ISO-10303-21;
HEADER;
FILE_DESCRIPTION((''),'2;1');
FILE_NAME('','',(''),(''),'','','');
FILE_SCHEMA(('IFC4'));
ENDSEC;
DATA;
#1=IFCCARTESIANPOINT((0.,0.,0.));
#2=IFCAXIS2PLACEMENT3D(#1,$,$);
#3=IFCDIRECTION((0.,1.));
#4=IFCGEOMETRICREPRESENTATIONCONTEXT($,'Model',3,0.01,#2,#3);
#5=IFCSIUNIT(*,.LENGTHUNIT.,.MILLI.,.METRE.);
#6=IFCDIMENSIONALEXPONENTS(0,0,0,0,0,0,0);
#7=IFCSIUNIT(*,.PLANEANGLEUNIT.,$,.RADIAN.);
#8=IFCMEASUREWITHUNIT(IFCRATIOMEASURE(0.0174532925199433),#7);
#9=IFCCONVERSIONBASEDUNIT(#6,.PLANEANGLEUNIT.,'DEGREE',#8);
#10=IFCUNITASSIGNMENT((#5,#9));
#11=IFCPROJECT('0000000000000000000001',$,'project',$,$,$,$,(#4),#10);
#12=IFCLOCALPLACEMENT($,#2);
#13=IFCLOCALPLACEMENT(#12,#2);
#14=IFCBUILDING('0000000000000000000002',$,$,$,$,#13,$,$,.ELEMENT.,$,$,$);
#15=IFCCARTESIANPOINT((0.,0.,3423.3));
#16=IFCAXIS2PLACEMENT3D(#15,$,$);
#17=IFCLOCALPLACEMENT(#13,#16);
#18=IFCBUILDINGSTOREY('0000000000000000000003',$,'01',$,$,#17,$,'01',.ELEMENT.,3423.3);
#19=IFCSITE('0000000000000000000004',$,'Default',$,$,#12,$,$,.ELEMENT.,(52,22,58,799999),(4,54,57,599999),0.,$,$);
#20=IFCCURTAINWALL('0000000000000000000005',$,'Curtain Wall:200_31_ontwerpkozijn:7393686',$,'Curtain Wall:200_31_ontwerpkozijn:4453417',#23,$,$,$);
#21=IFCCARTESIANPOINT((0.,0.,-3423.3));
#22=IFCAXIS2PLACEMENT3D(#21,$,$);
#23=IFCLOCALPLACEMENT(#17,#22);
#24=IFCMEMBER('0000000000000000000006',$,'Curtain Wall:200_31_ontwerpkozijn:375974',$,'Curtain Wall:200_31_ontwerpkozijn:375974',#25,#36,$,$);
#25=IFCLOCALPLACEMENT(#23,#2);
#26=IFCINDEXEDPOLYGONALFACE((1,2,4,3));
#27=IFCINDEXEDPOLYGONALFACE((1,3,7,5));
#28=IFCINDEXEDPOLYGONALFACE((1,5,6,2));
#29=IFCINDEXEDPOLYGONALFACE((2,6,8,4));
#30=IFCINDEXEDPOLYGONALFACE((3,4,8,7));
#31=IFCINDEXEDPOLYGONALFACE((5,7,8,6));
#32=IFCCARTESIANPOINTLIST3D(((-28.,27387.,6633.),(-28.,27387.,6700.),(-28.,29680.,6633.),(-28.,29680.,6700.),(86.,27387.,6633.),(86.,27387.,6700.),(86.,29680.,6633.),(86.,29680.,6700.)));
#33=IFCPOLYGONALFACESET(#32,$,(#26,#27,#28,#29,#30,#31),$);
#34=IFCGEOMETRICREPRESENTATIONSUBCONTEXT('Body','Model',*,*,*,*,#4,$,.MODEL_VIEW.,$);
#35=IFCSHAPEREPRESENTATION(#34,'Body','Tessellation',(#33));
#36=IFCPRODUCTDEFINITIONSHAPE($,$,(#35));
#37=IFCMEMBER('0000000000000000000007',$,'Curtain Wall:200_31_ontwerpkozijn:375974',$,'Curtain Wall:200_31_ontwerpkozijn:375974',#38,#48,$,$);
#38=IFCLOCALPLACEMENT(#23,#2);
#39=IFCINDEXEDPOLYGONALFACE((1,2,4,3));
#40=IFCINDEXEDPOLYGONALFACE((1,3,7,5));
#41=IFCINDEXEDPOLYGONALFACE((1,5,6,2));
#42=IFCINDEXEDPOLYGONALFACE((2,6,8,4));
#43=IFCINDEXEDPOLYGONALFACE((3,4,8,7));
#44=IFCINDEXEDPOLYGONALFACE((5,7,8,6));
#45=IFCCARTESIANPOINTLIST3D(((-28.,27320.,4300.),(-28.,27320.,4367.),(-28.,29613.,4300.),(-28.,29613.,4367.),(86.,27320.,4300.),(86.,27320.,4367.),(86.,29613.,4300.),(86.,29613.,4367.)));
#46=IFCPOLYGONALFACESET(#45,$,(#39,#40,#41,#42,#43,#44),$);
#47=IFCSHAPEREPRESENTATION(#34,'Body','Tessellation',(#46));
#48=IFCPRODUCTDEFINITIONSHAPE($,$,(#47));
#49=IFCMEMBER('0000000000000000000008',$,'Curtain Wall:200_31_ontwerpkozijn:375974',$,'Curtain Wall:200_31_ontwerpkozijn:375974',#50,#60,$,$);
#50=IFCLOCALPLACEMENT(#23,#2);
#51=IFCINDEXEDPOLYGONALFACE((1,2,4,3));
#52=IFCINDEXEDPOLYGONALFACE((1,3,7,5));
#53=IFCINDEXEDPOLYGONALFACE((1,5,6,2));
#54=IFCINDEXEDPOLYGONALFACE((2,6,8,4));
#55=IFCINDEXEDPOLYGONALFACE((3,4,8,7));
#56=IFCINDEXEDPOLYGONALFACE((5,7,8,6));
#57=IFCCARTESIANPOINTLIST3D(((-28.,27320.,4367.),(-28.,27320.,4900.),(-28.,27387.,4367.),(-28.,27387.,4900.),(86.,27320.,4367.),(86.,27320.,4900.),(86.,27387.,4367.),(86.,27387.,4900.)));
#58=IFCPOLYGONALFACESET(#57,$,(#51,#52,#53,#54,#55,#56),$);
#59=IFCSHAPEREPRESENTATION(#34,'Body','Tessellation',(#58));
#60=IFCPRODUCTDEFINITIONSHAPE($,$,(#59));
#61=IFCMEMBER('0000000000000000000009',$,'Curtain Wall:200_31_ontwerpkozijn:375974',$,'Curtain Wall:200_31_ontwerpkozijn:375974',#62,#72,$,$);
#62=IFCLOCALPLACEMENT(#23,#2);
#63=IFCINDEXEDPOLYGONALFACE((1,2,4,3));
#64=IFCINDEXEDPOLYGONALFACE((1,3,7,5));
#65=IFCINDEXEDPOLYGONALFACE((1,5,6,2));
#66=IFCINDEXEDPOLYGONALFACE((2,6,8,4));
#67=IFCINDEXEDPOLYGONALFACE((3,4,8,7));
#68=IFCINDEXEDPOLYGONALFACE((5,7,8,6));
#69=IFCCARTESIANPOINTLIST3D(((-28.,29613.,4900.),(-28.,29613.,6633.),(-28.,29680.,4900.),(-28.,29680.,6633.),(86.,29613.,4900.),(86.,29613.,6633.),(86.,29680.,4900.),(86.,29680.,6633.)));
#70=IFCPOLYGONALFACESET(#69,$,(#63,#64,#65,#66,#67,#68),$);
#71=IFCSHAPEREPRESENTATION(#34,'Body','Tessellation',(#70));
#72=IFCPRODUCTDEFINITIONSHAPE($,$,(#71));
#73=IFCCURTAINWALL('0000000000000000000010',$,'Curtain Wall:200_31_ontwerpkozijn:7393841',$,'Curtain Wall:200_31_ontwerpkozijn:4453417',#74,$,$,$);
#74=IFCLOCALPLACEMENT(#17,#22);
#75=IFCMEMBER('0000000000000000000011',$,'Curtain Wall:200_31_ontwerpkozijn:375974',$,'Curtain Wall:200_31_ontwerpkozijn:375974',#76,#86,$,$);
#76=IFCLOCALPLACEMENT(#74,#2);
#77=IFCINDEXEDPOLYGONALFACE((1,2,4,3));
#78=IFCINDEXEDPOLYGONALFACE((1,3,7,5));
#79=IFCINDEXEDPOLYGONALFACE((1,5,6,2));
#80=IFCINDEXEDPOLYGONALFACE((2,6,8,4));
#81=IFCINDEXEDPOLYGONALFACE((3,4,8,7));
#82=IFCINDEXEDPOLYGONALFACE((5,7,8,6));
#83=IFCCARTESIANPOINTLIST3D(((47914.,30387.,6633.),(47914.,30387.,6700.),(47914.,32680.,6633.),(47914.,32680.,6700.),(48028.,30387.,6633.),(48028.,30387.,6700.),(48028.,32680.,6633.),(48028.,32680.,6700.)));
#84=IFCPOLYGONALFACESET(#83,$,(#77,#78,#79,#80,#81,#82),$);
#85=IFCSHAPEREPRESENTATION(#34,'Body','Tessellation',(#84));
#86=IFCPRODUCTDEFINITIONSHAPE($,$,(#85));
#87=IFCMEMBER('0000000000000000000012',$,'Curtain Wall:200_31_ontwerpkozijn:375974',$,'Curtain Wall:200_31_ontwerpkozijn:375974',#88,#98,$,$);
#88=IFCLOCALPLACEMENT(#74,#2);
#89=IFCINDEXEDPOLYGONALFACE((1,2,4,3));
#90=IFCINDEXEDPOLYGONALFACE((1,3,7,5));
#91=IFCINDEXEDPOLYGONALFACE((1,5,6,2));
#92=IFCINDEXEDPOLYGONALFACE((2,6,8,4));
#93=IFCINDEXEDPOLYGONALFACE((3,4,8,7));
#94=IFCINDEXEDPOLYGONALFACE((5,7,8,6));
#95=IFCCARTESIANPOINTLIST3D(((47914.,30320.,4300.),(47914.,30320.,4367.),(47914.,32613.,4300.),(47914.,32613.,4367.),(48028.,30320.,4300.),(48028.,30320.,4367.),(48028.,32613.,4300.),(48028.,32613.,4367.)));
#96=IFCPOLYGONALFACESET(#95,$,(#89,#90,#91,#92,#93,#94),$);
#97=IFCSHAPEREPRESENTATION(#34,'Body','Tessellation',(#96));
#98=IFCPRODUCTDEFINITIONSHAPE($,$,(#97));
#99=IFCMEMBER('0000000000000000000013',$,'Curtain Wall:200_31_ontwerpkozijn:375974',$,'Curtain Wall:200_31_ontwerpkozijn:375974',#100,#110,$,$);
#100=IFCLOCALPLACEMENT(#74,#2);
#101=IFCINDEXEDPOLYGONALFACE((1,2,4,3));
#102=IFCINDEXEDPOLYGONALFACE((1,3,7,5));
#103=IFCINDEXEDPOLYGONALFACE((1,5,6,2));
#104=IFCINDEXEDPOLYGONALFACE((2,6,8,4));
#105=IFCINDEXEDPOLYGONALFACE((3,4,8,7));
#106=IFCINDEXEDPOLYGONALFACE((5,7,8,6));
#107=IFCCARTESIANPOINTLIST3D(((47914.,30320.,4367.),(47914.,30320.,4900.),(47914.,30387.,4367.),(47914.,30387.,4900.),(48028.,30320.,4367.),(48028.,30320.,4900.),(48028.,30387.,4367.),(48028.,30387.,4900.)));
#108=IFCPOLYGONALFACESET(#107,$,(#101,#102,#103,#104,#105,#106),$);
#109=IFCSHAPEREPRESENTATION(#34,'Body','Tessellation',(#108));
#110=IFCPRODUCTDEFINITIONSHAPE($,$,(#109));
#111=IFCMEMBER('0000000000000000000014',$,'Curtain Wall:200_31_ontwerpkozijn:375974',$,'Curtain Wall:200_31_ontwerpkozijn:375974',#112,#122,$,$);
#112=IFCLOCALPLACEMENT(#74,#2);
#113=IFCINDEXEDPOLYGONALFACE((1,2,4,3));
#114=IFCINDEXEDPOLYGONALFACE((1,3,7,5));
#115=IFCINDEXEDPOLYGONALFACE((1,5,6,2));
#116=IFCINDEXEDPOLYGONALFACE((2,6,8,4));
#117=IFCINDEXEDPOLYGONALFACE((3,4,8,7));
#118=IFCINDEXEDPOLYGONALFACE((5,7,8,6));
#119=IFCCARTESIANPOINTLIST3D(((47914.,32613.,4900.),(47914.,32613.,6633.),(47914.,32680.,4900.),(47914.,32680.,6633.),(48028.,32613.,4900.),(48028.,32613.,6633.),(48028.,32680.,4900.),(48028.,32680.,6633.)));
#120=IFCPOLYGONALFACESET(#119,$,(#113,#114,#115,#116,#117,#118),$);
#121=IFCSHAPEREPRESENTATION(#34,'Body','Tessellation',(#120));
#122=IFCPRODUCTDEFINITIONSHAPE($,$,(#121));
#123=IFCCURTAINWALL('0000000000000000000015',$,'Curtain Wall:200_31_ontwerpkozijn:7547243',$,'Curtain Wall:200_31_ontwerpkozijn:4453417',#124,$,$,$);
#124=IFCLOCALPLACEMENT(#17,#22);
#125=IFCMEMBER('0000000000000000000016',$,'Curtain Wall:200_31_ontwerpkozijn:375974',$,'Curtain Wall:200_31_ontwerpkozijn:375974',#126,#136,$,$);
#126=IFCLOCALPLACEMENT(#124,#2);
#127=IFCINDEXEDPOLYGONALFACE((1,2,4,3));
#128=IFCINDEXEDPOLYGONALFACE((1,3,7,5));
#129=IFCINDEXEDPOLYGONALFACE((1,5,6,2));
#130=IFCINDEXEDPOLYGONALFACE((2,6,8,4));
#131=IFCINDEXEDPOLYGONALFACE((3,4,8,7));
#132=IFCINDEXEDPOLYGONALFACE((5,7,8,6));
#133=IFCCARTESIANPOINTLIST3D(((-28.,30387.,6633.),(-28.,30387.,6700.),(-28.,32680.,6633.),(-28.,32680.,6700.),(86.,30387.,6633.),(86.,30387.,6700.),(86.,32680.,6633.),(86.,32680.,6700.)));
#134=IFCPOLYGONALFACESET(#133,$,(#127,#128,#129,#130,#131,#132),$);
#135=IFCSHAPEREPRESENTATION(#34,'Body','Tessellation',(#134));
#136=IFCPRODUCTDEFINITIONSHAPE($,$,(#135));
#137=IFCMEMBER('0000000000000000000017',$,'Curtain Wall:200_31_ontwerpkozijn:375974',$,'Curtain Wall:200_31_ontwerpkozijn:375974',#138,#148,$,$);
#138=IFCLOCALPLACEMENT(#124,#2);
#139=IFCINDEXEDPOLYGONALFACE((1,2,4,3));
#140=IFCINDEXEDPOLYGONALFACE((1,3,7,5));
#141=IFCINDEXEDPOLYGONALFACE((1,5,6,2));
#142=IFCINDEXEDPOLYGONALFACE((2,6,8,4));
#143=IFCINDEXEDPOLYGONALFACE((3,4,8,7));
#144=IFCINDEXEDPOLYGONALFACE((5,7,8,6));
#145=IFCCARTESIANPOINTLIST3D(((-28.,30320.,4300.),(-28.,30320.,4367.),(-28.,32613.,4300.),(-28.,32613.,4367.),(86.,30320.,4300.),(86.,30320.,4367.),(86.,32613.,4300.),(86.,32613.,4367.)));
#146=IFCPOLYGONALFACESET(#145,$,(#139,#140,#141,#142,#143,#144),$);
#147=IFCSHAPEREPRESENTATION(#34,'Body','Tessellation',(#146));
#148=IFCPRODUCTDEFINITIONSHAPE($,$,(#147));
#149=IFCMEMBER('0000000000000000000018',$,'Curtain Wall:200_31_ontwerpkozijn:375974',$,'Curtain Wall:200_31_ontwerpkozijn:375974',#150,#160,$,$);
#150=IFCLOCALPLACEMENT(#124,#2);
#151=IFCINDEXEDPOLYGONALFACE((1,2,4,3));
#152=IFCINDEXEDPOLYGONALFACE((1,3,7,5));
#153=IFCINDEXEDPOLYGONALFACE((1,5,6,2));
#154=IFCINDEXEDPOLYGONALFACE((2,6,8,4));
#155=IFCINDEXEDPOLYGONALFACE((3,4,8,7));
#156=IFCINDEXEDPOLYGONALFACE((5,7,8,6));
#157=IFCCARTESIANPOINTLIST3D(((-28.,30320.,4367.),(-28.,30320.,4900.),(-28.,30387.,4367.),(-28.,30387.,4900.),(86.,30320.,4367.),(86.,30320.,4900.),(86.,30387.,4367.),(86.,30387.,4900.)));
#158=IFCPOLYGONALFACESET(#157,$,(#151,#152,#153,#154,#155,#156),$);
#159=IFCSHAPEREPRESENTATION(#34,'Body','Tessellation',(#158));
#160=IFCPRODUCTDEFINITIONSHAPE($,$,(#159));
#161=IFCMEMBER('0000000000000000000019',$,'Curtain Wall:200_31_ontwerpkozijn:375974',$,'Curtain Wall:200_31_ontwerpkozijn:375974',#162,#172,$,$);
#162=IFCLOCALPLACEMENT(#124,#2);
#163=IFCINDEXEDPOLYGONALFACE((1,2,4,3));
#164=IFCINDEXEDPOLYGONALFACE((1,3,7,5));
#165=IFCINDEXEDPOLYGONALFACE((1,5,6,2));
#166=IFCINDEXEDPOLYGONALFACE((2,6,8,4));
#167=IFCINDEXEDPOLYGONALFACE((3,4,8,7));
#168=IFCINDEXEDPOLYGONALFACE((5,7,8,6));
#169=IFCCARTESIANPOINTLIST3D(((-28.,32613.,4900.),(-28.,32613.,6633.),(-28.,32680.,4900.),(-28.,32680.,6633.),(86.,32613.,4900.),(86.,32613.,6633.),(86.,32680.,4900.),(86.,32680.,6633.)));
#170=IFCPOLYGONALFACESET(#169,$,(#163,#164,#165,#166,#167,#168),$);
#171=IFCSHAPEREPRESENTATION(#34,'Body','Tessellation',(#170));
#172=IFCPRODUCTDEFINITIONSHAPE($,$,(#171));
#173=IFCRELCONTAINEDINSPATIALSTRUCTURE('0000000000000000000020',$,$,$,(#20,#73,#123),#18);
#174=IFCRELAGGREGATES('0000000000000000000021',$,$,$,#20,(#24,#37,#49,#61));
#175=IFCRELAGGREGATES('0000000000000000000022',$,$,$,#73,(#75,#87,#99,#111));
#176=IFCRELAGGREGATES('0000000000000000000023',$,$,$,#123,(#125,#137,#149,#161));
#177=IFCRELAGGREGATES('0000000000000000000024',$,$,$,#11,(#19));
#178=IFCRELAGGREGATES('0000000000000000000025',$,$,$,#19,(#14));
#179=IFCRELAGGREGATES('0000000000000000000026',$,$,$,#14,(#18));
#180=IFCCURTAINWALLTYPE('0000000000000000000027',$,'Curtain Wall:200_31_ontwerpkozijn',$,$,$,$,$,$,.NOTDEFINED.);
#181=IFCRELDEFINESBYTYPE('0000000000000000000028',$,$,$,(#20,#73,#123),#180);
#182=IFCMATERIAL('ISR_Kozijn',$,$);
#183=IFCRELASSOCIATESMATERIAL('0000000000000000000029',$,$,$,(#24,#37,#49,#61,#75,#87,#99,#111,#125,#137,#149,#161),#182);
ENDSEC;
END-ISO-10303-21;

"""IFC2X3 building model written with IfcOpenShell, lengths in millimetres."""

from ifc_helpers import new_model, entity, si_unit, converted_unit, direction, frame, frame_2d, origin, origin_2d_with_axis, place, context, subcontext, project, spatial, rectangle, extrude, material, type_object, element, aggregate, save


model = new_model("IFC2X3")

# Units and contexts
model_context = context("Model", 3, precision=0.01, world=origin(), true_north=direction((0.0, 1.0)))
body_context = subcontext(model_context, "Body", "Model", "MODEL_VIEW")
ifc_project = project(units=[si_unit("LENGTHUNIT", "METRE", prefix="MILLI"), converted_unit("PLANEANGLEUNIT", "DEGREE", entity("IfcRatioMeasure", 0.0174532925199433), si_unit("PLANEANGLEUNIT", "RADIAN"), dimensions=[0, 0, 0, 0, 0, 0, 0])], contexts=[model_context])

# Site, building, storey
site_placement = place(None, origin())
site = spatial("IfcSite", under=ifc_project, at=site_placement, Name="Default", CompositionType="ELEMENT", RefLatitude=(52, 22, 58, 799999), RefLongitude=(4, 54, 57, 599999), RefElevation=0.0)
building_placement = place(site_placement, origin())
building = spatial("IfcBuilding", under=site, at=building_placement, CompositionType="ELEMENT")
storey_placement = place(building_placement, frame((0.0, 0.0, 3423.3)))
storey = spatial("IfcBuildingStorey", under=building, at=storey_placement, Name="01", LongName="01", CompositionType="ELEMENT", Elevation=3423.3)

# Curtain walls, members
curtain_wall_type = type_object("IfcCurtainWallType", Name="Curtain Wall:200_31_ontwerpkozijn", PredefinedType="NOTDEFINED")
curtain_wall_1_placement = place(storey_placement, frame((0.0, 0.0, -3423.3)))
curtain_wall_1 = element("IfcCurtainWall", 1, at=curtain_wall_1_placement, inside=storey, type_object=curtain_wall_type, Name="Curtain Wall:200_31_ontwerpkozijn:7393686", ObjectType="Curtain Wall:200_31_ontwerpkozijn:4453417")
ifc_material_1 = material(Name="ISR_Kozijn")
member_1_placement = place(curtain_wall_1_placement, origin())
member_1 = element("IfcMember", 2, at=member_1_placement, material=ifc_material_1, Name="Curtain Wall:200_31_ontwerpkozijn:375974", ObjectType="Curtain Wall:200_31_ontwerpkozijn:375974", context=body_context, shape_type="SweptSolid", body=[
    extrude(rectangle(XDim=67.0, YDim=114.0, at=origin_2d_with_axis()), frame((29.0, 27387.0, 6666.5), z_axis=(0.0, 1.0, 0.0), x_axis=(0.0, 0.0, -1.0)), (0.0, 0.0, 1.0), 2293.0),
])
member_2_placement = place(curtain_wall_1_placement, origin())
member_2 = element("IfcMember", 3, at=member_2_placement, material=ifc_material_1, Name="Curtain Wall:200_31_ontwerpkozijn:375974", ObjectType="Curtain Wall:200_31_ontwerpkozijn:375974", context=body_context, shape_type="SweptSolid", body=[
    extrude(rectangle(XDim=67.0, YDim=114.0, at=frame_2d((0.0, 0.0), x_axis=(1.0, 0.0))), frame((29.0, 29613.0, 4333.5), z_axis=(0.0, -1.0, 0.0), x_axis=(0.0, 0.0, -1.0)), (0.0, 0.0, 1.0), 2293.0),
])
member_3_placement = place(curtain_wall_1_placement, origin())
member_3 = element("IfcMember", 4, at=member_3_placement, material=ifc_material_1, Name="Curtain Wall:200_31_ontwerpkozijn:375974", ObjectType="Curtain Wall:200_31_ontwerpkozijn:375974", context=body_context, shape_type="SweptSolid", body=[
    extrude(rectangle(XDim=114.0, YDim=67.0, at=origin_2d_with_axis()), frame((29.0, 27353.5, 4367.0), z_axis=(0.0, 0.0, 1.0), x_axis=(-1.0, 0.0, 0.0)), (0.0, 0.0, 1.0), 533.0),
])
member_4_placement = place(curtain_wall_1_placement, origin())
member_4 = element("IfcMember", 5, at=member_4_placement, material=ifc_material_1, Name="Curtain Wall:200_31_ontwerpkozijn:375974", ObjectType="Curtain Wall:200_31_ontwerpkozijn:375974", context=body_context, shape_type="SweptSolid", body=[
    extrude(rectangle(XDim=114.0, YDim=67.0, at=origin_2d_with_axis()), frame((29.0, 29646.5, 6633.0), z_axis=(0.0, 0.0, -1.0), x_axis=(-1.0, 0.0, 0.0)), (0.0, 0.0, 1.0), 1733.0),
])
aggregate(curtain_wall_1, [member_1, member_2, member_3, member_4])
curtain_wall_2_placement = place(storey_placement, frame((0.0, 0.0, -3423.3)))
curtain_wall_2 = element("IfcCurtainWall", 6, at=curtain_wall_2_placement, inside=storey, type_object=curtain_wall_type, Name="Curtain Wall:200_31_ontwerpkozijn:7393841", ObjectType="Curtain Wall:200_31_ontwerpkozijn:4453417")
member_5_placement = place(curtain_wall_2_placement, origin())
member_5 = element("IfcMember", 7, at=member_5_placement, material=ifc_material_1, Name="Curtain Wall:200_31_ontwerpkozijn:375974", ObjectType="Curtain Wall:200_31_ontwerpkozijn:375974", context=body_context, shape_type="SweptSolid", body=[
    extrude(rectangle(XDim=67.0, YDim=114.0, at=frame_2d((0.0, 0.0), x_axis=(1.0, 0.0))), frame((47971.0, 30387.0, 6666.5), z_axis=(0.0, 1.0, 0.0), x_axis=(0.0, 0.0, -1.0)), (0.0, 0.0, 1.0), 2293.0),
])
member_6_placement = place(curtain_wall_2_placement, origin())
member_6 = element("IfcMember", 8, at=member_6_placement, material=ifc_material_1, Name="Curtain Wall:200_31_ontwerpkozijn:375974", ObjectType="Curtain Wall:200_31_ontwerpkozijn:375974", context=body_context, shape_type="SweptSolid", body=[
    extrude(rectangle(XDim=67.0, YDim=114.0, at=frame_2d((0.0, 0.0), x_axis=(1.0, 0.0))), frame((47971.0, 32613.0, 4333.5), z_axis=(0.0, -1.0, 0.0), x_axis=(0.0, 0.0, -1.0)), (0.0, 0.0, 1.0), 2293.0),
])
member_7_placement = place(curtain_wall_2_placement, origin())
member_7 = element("IfcMember", 9, at=member_7_placement, material=ifc_material_1, Name="Curtain Wall:200_31_ontwerpkozijn:375974", ObjectType="Curtain Wall:200_31_ontwerpkozijn:375974", context=body_context, shape_type="SweptSolid", body=[
    extrude(rectangle(XDim=114.0, YDim=67.0, at=frame_2d((0.0, 0.0), x_axis=(1.0, 0.0))), frame((47971.0, 30353.5, 4367.0), z_axis=(0.0, 0.0, 1.0), x_axis=(-1.0, 0.0, 0.0)), (0.0, 0.0, 1.0), 533.0),
])
member_8_placement = place(curtain_wall_2_placement, origin())
member_8 = element("IfcMember", 10, at=member_8_placement, material=ifc_material_1, Name="Curtain Wall:200_31_ontwerpkozijn:375974", ObjectType="Curtain Wall:200_31_ontwerpkozijn:375974", context=body_context, shape_type="SweptSolid", body=[
    extrude(rectangle(XDim=114.0, YDim=67.0, at=frame_2d((0.0, 0.0), x_axis=(1.0, 0.0))), frame((47971.0, 32646.5, 6633.0), z_axis=(0.0, 0.0, -1.0), x_axis=(-1.0, 0.0, 0.0)), (0.0, 0.0, 1.0), 1733.0),
])
aggregate(curtain_wall_2, [member_5, member_6, member_7, member_8])
curtain_wall_3_placement = place(storey_placement, frame((0.0, 0.0, -3423.3)))
curtain_wall_3 = element("IfcCurtainWall", 11, at=curtain_wall_3_placement, inside=storey, type_object=curtain_wall_type, Name="Curtain Wall:200_31_ontwerpkozijn:7547243", ObjectType="Curtain Wall:200_31_ontwerpkozijn:4453417")
member_9_placement = place(curtain_wall_3_placement, origin())
member_9 = element("IfcMember", 12, at=member_9_placement, material=ifc_material_1, Name="Curtain Wall:200_31_ontwerpkozijn:375974", ObjectType="Curtain Wall:200_31_ontwerpkozijn:375974", context=body_context, shape_type="SweptSolid", body=[
    extrude(rectangle(XDim=67.0, YDim=114.0, at=origin_2d_with_axis()), frame((29.0, 30387.0, 6666.5), z_axis=(0.0, 1.0, 0.0), x_axis=(0.0, 0.0, -1.0)), (0.0, 0.0, 1.0), 2293.0),
])
member_10_placement = place(curtain_wall_3_placement, origin())
member_10 = element("IfcMember", 13, at=member_10_placement, material=ifc_material_1, Name="Curtain Wall:200_31_ontwerpkozijn:375974", ObjectType="Curtain Wall:200_31_ontwerpkozijn:375974", context=body_context, shape_type="SweptSolid", body=[
    extrude(rectangle(XDim=67.0, YDim=114.0, at=frame_2d((0.0, 0.0), x_axis=(1.0, 0.0))), frame((29.0, 32613.0, 4333.5), z_axis=(0.0, -1.0, 0.0), x_axis=(0.0, 0.0, -1.0)), (0.0, 0.0, 1.0), 2293.0),
])
member_11_placement = place(curtain_wall_3_placement, origin())
member_11 = element("IfcMember", 14, at=member_11_placement, material=ifc_material_1, Name="Curtain Wall:200_31_ontwerpkozijn:375974", ObjectType="Curtain Wall:200_31_ontwerpkozijn:375974", context=body_context, shape_type="SweptSolid", body=[
    extrude(rectangle(XDim=114.0, YDim=67.0, at=origin_2d_with_axis()), frame((29.0, 30353.5, 4367.0), z_axis=(0.0, 0.0, 1.0), x_axis=(-1.0, 0.0, 0.0)), (0.0, 0.0, 1.0), 533.0),
])
member_12_placement = place(curtain_wall_3_placement, origin())
member_12 = element("IfcMember", 15, at=member_12_placement, material=ifc_material_1, Name="Curtain Wall:200_31_ontwerpkozijn:375974", ObjectType="Curtain Wall:200_31_ontwerpkozijn:375974", context=body_context, shape_type="SweptSolid", body=[
    extrude(rectangle(XDim=114.0, YDim=67.0, at=origin_2d_with_axis()), frame((29.0, 32646.5, 6633.0), z_axis=(0.0, 0.0, -1.0), x_axis=(-1.0, 0.0, 0.0)), (0.0, 0.0, 1.0), 1733.0),
])
aggregate(curtain_wall_3, [member_9, member_10, member_11, member_12])

save(model, "model.ifc")
